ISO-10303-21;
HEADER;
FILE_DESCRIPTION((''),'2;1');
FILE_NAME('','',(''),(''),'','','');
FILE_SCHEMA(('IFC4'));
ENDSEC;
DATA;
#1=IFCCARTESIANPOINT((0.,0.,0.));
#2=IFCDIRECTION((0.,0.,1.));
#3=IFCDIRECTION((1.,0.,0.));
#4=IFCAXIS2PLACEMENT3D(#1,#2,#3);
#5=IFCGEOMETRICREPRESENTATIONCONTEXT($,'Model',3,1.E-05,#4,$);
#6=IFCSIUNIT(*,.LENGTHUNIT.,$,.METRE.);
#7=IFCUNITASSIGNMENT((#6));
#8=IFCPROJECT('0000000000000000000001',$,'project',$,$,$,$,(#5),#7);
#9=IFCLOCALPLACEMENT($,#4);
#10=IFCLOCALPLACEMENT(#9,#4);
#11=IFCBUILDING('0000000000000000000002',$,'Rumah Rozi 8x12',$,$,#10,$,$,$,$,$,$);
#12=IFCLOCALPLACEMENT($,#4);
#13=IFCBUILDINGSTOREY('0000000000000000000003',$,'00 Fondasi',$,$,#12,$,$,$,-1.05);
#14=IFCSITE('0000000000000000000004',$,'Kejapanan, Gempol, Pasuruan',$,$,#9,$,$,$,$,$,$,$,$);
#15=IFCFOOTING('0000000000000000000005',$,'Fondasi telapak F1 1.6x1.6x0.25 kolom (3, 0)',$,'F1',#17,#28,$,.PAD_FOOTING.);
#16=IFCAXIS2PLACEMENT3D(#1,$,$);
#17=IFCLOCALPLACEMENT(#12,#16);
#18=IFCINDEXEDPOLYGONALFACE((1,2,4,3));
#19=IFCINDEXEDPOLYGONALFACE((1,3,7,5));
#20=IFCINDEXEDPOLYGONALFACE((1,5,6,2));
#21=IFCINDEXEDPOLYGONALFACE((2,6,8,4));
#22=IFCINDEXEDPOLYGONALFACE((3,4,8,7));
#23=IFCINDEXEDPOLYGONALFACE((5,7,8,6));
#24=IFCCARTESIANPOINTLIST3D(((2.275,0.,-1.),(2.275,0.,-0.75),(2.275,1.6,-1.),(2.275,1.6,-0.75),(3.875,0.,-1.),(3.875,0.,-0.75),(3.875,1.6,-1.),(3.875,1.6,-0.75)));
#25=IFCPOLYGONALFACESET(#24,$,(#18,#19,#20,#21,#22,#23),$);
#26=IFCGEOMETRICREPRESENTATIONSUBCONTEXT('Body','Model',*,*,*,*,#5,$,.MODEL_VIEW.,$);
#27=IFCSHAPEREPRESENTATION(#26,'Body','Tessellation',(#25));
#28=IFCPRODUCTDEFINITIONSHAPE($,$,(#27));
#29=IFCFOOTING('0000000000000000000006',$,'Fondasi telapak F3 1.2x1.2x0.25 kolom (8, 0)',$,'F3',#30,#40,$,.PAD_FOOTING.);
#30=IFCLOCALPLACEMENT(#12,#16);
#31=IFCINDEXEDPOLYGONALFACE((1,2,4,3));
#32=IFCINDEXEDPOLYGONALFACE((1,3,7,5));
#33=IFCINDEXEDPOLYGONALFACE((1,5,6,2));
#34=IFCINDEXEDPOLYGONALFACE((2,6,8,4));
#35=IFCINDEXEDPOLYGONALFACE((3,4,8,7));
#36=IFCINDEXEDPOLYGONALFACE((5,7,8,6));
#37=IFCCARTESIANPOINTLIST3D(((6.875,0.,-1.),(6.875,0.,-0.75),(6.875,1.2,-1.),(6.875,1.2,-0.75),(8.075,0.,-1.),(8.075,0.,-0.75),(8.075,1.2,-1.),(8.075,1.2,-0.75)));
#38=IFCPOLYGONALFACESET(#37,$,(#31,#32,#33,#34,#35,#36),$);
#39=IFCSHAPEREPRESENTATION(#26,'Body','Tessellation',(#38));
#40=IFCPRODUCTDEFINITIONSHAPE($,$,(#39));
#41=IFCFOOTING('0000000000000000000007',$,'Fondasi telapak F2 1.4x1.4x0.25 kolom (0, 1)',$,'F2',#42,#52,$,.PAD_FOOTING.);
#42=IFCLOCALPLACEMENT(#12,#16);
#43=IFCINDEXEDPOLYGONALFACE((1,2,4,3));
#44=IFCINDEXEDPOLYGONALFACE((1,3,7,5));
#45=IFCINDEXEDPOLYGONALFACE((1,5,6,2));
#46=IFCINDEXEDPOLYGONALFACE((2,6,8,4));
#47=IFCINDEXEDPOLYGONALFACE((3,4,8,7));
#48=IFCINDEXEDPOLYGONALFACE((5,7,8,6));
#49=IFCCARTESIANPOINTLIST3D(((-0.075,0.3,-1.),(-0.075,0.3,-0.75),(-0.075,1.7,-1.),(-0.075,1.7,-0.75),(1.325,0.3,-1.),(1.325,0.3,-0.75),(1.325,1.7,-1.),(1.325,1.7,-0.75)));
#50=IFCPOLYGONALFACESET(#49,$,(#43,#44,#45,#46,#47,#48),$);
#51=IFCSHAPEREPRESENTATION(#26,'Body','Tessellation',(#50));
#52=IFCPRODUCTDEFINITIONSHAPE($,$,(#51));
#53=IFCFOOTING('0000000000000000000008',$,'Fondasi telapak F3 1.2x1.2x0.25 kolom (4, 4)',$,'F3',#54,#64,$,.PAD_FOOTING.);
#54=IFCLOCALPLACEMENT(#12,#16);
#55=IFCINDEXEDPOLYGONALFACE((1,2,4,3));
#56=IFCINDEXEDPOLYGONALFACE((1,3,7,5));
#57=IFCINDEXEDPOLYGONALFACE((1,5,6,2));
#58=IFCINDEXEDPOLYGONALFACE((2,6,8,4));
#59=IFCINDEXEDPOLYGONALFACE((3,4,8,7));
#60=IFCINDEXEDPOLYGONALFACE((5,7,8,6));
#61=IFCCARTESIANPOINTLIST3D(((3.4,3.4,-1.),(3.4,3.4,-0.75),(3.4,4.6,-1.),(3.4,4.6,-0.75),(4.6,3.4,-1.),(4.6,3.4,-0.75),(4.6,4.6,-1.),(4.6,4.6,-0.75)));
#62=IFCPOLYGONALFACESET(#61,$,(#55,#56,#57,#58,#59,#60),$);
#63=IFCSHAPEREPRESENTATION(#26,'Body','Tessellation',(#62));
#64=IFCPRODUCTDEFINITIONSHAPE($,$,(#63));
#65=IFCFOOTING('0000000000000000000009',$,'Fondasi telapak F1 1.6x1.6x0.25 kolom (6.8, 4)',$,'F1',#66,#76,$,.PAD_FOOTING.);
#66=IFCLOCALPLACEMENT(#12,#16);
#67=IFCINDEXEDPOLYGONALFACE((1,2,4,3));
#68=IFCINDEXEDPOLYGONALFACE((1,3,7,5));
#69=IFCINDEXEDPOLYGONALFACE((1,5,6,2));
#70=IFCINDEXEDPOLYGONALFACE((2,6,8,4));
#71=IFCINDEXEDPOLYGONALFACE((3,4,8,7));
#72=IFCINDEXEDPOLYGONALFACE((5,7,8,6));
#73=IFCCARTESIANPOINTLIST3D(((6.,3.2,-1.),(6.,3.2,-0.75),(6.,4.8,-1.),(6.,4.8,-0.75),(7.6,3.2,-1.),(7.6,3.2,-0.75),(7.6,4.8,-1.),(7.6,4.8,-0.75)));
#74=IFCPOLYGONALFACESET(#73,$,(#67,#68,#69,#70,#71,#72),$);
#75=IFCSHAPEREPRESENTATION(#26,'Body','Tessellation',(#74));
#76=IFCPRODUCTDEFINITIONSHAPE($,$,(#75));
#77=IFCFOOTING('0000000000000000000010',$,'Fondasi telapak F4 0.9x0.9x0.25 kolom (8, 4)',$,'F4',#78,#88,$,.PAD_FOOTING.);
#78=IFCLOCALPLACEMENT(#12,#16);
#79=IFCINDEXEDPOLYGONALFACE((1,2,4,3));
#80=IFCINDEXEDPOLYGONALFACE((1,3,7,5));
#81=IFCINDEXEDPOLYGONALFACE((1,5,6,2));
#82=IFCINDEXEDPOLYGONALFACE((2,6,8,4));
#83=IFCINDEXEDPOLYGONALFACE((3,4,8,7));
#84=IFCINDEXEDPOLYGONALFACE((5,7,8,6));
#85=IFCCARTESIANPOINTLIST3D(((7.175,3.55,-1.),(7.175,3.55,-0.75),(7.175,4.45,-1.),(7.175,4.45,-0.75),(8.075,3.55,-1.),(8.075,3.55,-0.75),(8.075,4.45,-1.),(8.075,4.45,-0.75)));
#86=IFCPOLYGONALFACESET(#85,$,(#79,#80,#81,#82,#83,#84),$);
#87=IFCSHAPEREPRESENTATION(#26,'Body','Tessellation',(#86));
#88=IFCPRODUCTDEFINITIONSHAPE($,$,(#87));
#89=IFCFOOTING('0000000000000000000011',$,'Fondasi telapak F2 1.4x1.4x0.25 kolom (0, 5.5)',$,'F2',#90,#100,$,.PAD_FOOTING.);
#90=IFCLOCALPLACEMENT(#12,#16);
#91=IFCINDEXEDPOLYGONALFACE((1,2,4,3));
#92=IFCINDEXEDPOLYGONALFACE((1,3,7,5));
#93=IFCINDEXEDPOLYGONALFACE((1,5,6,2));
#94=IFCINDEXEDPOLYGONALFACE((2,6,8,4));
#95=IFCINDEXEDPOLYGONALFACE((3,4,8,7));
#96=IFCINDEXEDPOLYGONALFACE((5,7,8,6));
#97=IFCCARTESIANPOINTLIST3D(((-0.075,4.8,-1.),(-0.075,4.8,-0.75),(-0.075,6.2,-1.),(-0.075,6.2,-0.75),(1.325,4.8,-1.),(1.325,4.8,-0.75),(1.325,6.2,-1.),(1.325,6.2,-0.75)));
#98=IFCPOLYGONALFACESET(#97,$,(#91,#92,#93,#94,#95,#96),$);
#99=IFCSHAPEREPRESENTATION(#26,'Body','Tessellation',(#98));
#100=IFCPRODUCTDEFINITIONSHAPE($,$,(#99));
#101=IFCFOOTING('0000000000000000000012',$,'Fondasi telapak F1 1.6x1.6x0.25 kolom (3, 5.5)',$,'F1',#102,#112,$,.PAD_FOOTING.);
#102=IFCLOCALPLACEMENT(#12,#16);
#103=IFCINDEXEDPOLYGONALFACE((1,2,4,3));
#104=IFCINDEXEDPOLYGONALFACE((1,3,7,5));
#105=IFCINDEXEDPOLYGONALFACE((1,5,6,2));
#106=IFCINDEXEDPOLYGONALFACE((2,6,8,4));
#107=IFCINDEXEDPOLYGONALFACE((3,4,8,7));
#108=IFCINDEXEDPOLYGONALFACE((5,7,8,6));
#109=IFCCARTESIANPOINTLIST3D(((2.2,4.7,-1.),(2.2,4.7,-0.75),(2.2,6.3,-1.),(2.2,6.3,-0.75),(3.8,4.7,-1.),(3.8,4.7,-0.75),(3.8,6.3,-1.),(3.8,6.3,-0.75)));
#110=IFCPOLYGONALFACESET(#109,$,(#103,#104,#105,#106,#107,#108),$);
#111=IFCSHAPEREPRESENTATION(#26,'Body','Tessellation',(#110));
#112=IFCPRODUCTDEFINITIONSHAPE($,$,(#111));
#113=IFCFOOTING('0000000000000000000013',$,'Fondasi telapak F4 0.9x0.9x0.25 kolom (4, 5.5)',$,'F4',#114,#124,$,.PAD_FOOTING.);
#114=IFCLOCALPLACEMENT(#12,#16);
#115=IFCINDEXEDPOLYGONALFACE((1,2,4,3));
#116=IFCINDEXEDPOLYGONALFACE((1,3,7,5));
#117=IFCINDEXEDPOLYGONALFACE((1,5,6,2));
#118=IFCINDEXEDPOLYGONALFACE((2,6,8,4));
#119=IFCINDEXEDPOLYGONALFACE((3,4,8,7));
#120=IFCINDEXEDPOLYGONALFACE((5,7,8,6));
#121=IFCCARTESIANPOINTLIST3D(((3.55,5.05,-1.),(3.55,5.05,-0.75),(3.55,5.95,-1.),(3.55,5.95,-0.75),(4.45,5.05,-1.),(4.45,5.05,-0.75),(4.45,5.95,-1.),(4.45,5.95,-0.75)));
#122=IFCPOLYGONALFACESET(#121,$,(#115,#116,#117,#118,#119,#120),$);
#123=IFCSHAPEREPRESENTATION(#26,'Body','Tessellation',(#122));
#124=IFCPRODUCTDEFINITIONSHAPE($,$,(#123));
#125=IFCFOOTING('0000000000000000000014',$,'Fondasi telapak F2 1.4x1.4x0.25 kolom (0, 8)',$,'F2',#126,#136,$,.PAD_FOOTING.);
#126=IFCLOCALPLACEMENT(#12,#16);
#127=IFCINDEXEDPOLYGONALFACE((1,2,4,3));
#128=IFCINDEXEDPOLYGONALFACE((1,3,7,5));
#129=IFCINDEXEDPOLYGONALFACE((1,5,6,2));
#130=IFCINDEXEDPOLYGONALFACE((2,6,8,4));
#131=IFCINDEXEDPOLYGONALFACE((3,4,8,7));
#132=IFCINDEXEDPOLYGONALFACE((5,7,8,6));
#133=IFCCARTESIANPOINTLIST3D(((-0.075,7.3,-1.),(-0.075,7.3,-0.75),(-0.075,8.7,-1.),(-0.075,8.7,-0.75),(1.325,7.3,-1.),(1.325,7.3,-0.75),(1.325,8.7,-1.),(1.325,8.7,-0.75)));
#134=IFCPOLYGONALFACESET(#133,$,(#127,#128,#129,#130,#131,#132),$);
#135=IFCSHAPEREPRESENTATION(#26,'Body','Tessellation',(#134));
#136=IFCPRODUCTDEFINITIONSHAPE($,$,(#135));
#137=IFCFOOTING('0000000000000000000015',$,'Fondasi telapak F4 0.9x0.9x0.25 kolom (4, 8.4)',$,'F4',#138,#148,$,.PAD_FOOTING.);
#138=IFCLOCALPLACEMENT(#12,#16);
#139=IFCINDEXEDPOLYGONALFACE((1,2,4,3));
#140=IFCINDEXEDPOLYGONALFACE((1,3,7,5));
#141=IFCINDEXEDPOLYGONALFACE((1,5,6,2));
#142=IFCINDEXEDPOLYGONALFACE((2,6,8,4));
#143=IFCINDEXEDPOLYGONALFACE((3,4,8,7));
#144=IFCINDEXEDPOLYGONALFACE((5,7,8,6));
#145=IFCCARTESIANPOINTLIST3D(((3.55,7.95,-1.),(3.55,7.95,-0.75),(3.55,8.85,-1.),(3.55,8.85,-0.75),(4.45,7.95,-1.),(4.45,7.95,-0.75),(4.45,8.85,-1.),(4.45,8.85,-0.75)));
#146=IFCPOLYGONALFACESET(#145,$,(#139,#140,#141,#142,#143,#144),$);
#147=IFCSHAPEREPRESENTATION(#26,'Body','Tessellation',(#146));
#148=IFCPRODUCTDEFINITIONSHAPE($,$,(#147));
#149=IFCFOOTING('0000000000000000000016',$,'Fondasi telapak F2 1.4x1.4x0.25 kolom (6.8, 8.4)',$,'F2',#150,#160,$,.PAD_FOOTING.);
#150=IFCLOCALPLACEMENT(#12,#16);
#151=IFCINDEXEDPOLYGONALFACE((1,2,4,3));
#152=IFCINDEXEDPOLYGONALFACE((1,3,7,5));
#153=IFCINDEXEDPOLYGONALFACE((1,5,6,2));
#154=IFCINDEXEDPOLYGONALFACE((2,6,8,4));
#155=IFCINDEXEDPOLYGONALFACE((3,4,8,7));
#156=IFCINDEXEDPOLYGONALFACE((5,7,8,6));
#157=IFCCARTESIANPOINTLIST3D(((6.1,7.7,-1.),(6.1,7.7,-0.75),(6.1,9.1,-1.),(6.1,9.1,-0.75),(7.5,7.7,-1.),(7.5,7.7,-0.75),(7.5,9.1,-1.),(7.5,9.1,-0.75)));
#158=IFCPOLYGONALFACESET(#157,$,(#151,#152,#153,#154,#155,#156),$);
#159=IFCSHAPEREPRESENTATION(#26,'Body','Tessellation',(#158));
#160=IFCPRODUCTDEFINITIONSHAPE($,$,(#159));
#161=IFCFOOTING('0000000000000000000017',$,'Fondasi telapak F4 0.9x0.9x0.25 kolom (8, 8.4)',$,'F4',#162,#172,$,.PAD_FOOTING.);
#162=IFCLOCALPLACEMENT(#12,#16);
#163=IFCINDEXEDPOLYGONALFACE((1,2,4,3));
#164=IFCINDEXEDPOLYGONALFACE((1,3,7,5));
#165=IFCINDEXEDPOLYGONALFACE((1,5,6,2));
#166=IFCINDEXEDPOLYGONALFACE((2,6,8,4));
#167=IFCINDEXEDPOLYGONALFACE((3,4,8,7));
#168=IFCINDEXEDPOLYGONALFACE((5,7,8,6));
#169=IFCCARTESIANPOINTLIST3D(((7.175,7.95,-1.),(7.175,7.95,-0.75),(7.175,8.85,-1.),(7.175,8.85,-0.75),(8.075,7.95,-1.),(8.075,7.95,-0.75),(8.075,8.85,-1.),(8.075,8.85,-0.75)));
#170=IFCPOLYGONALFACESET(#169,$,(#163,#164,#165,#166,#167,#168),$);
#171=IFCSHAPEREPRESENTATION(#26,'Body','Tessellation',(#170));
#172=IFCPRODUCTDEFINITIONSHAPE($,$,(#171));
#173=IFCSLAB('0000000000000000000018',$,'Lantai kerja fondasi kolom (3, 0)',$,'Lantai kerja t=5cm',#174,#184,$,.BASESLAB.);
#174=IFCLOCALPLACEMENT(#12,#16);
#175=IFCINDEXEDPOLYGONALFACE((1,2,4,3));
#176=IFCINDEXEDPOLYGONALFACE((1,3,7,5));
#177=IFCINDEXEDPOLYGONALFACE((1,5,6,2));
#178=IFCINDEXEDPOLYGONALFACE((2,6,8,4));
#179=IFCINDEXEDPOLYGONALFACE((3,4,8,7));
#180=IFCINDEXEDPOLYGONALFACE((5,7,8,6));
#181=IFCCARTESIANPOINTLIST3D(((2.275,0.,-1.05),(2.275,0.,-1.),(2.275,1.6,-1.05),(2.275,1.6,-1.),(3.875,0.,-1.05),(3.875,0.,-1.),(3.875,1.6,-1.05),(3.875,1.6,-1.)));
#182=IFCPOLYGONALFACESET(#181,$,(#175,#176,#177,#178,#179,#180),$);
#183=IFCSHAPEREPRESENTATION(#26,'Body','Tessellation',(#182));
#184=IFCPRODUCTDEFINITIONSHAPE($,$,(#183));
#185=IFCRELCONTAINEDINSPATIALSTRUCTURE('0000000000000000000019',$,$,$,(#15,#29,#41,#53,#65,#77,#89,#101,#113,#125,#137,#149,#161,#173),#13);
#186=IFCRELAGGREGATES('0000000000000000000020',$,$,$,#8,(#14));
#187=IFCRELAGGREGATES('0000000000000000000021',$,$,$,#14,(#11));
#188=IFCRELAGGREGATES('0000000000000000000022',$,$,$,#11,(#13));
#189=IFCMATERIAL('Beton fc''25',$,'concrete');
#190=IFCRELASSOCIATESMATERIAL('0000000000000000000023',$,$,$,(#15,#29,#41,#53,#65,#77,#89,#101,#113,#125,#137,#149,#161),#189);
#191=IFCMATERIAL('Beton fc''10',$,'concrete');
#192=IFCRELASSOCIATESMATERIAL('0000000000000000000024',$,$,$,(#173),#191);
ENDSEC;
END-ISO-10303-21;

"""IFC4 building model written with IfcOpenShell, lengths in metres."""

from ifc_helpers import new_model, si_unit, frame, origin_with_axes, place, context, subcontext, project, spatial, line, indexed_curve, outline, extrude, material, element, save


model = new_model("IFC4")

# Units and contexts
model_context = context("Model", 3, precision=1e-05, world=origin_with_axes())
body_context = subcontext(model_context, "Body", "Model", "MODEL_VIEW")
ifc_project = project(units=[si_unit("LENGTHUNIT", "METRE")], contexts=[model_context])

# Site, building, storey
site_placement = place(None, origin_with_axes())
site = spatial("IfcSite", under=ifc_project, at=site_placement, Name="Kejapanan, Gempol, Pasuruan")
building_placement = place(site_placement, origin_with_axes())
building = spatial("IfcBuilding", under=site, at=building_placement, Name="Rumah Rozi 8x12")
storey_placement = place(None, origin_with_axes())
storey = spatial("IfcBuildingStorey", under=building, at=storey_placement, Name="00 Fondasi", Elevation=-1.05)

# Footings
ifc_material_1 = material(Name="Beton fc'25", Category="concrete")
footing_1_placement = place(storey_placement, origin_with_axes())
element("IfcFooting", 1, at=footing_1_placement, inside=storey, material=ifc_material_1, Name="Fondasi telapak F1 1.6x1.6x0.25 kolom (3, 0)", ObjectType="F1", PredefinedType="PAD_FOOTING", context=body_context, shape_type="SweptSolid", body=[
    extrude(outline(indexed_curve([(2.275, 0.0), (3.875, 0.0), (3.875, 1.6), (2.275, 1.6)], segments=[line(1, 2, 3, 4, 1)])), frame((0.0, 0.0, -1.0), z_axis=(0.0, 0.0, 1.0), x_axis=(1.0, 0.0, 0.0)), (0.0, 0.0, 1.0), 0.25),
])
footing_2_placement = place(storey_placement, origin_with_axes())
element("IfcFooting", 2, at=footing_2_placement, inside=storey, material=ifc_material_1, Name="Fondasi telapak F3 1.2x1.2x0.25 kolom (8, 0)", ObjectType="F3", PredefinedType="PAD_FOOTING", context=body_context, shape_type="SweptSolid", body=[
    extrude(outline(indexed_curve([(6.875, 0.0), (8.075, 0.0), (8.075, 1.2), (6.875, 1.2)], segments=[line(1, 2, 3, 4, 1)])), frame((0.0, 0.0, -1.0), z_axis=(0.0, 0.0, 1.0), x_axis=(1.0, 0.0, 0.0)), (0.0, 0.0, 1.0), 0.25),
])
footing_3_placement = place(storey_placement, origin_with_axes())
element("IfcFooting", 3, at=footing_3_placement, inside=storey, material=ifc_material_1, Name="Fondasi telapak F2 1.4x1.4x0.25 kolom (0, 1)", ObjectType="F2", PredefinedType="PAD_FOOTING", context=body_context, shape_type="SweptSolid", body=[
    extrude(outline(indexed_curve([(-0.075, 0.3), (1.325, 0.3), (1.325, 1.7), (-0.075, 1.7)], segments=[line(1, 2, 3, 4, 1)])), frame((0.0, 0.0, -1.0), z_axis=(0.0, 0.0, 1.0), x_axis=(1.0, 0.0, 0.0)), (0.0, 0.0, 1.0), 0.25),
])
footing_4_placement = place(storey_placement, origin_with_axes())
element("IfcFooting", 4, at=footing_4_placement, inside=storey, material=ifc_material_1, Name="Fondasi telapak F3 1.2x1.2x0.25 kolom (4, 4)", ObjectType="F3", PredefinedType="PAD_FOOTING", context=body_context, shape_type="SweptSolid", body=[
    extrude(outline(indexed_curve([(3.4, 3.4), (4.6, 3.4), (4.6, 4.6), (3.4, 4.6)], segments=[line(1, 2, 3, 4, 1)])), frame((0.0, 0.0, -1.0), z_axis=(0.0, 0.0, 1.0), x_axis=(1.0, 0.0, 0.0)), (0.0, 0.0, 1.0), 0.25),
])
footing_5_placement = place(storey_placement, origin_with_axes())
element("IfcFooting", 5, at=footing_5_placement, inside=storey, material=ifc_material_1, Name="Fondasi telapak F1 1.6x1.6x0.25 kolom (6.8, 4)", ObjectType="F1", PredefinedType="PAD_FOOTING", context=body_context, shape_type="SweptSolid", body=[
    extrude(outline(indexed_curve([(6.0, 3.2), (7.6, 3.2), (7.6, 4.8), (6.0, 4.8)], segments=[line(1, 2, 3, 4, 1)])), frame((0.0, 0.0, -1.0), z_axis=(0.0, 0.0, 1.0), x_axis=(1.0, 0.0, 0.0)), (0.0, 0.0, 1.0), 0.25),
])
footing_6_placement = place(storey_placement, origin_with_axes())
element("IfcFooting", 6, at=footing_6_placement, inside=storey, material=ifc_material_1, Name="Fondasi telapak F4 0.9x0.9x0.25 kolom (8, 4)", ObjectType="F4", PredefinedType="PAD_FOOTING", context=body_context, shape_type="SweptSolid", body=[
    extrude(outline(indexed_curve([(7.175, 3.55), (8.075, 3.55), (8.075, 4.45), (7.175, 4.45)], segments=[line(1, 2, 3, 4, 1)])), frame((0.0, 0.0, -1.0), z_axis=(0.0, 0.0, 1.0), x_axis=(1.0, 0.0, 0.0)), (0.0, 0.0, 1.0), 0.25),
])
footing_7_placement = place(storey_placement, origin_with_axes())
element("IfcFooting", 7, at=footing_7_placement, inside=storey, material=ifc_material_1, Name="Fondasi telapak F2 1.4x1.4x0.25 kolom (0, 5.5)", ObjectType="F2", PredefinedType="PAD_FOOTING", context=body_context, shape_type="SweptSolid", body=[
    extrude(outline(indexed_curve([(-0.075, 4.8), (1.325, 4.8), (1.325, 6.2), (-0.075, 6.2)], segments=[line(1, 2, 3, 4, 1)])), frame((0.0, 0.0, -1.0), z_axis=(0.0, 0.0, 1.0), x_axis=(1.0, 0.0, 0.0)), (0.0, 0.0, 1.0), 0.25),
])
footing_8_placement = place(storey_placement, origin_with_axes())
element("IfcFooting", 8, at=footing_8_placement, inside=storey, material=ifc_material_1, Name="Fondasi telapak F1 1.6x1.6x0.25 kolom (3, 5.5)", ObjectType="F1", PredefinedType="PAD_FOOTING", context=body_context, shape_type="SweptSolid", body=[
    extrude(outline(indexed_curve([(2.2, 4.7), (3.8, 4.7), (3.8, 6.3), (2.2, 6.3)], segments=[line(1, 2, 3, 4, 1)])), frame((0.0, 0.0, -1.0), z_axis=(0.0, 0.0, 1.0), x_axis=(1.0, 0.0, 0.0)), (0.0, 0.0, 1.0), 0.25),
])
footing_9_placement = place(storey_placement, origin_with_axes())
element("IfcFooting", 9, at=footing_9_placement, inside=storey, material=ifc_material_1, Name="Fondasi telapak F4 0.9x0.9x0.25 kolom (4, 5.5)", ObjectType="F4", PredefinedType="PAD_FOOTING", context=body_context, shape_type="SweptSolid", body=[
    extrude(outline(indexed_curve([(3.55, 5.05), (4.45, 5.05), (4.45, 5.95), (3.55, 5.95)], segments=[line(1, 2, 3, 4, 1)])), frame((0.0, 0.0, -1.0), z_axis=(0.0, 0.0, 1.0), x_axis=(1.0, 0.0, 0.0)), (0.0, 0.0, 1.0), 0.25),
])
footing_10_placement = place(storey_placement, origin_with_axes())
element("IfcFooting", 10, at=footing_10_placement, inside=storey, material=ifc_material_1, Name="Fondasi telapak F2 1.4x1.4x0.25 kolom (0, 8)", ObjectType="F2", PredefinedType="PAD_FOOTING", context=body_context, shape_type="SweptSolid", body=[
    extrude(outline(indexed_curve([(-0.075, 7.3), (1.325, 7.3), (1.325, 8.7), (-0.075, 8.7)], segments=[line(1, 2, 3, 4, 1)])), frame((0.0, 0.0, -1.0), z_axis=(0.0, 0.0, 1.0), x_axis=(1.0, 0.0, 0.0)), (0.0, 0.0, 1.0), 0.25),
])
footing_11_placement = place(storey_placement, origin_with_axes())
element("IfcFooting", 11, at=footing_11_placement, inside=storey, material=ifc_material_1, Name="Fondasi telapak F4 0.9x0.9x0.25 kolom (4, 8.4)", ObjectType="F4", PredefinedType="PAD_FOOTING", context=body_context, shape_type="SweptSolid", body=[
    extrude(outline(indexed_curve([(3.55, 7.95), (4.45, 7.95), (4.45, 8.85), (3.55, 8.85)], segments=[line(1, 2, 3, 4, 1)])), frame((0.0, 0.0, -1.0), z_axis=(0.0, 0.0, 1.0), x_axis=(1.0, 0.0, 0.0)), (0.0, 0.0, 1.0), 0.25),
])
footing_12_placement = place(storey_placement, origin_with_axes())
element("IfcFooting", 12, at=footing_12_placement, inside=storey, material=ifc_material_1, Name="Fondasi telapak F2 1.4x1.4x0.25 kolom (6.8, 8.4)", ObjectType="F2", PredefinedType="PAD_FOOTING", context=body_context, shape_type="SweptSolid", body=[
    extrude(outline(indexed_curve([(6.1, 7.7), (7.5, 7.7), (7.5, 9.1), (6.1, 9.1)], segments=[line(1, 2, 3, 4, 1)])), frame((0.0, 0.0, -1.0), z_axis=(0.0, 0.0, 1.0), x_axis=(1.0, 0.0, 0.0)), (0.0, 0.0, 1.0), 0.25),
])
footing_13_placement = place(storey_placement, origin_with_axes())
element("IfcFooting", 13, at=footing_13_placement, inside=storey, material=ifc_material_1, Name="Fondasi telapak F4 0.9x0.9x0.25 kolom (8, 8.4)", ObjectType="F4", PredefinedType="PAD_FOOTING", context=body_context, shape_type="SweptSolid", body=[
    extrude(outline(indexed_curve([(7.175, 7.95), (8.075, 7.95), (8.075, 8.85), (7.175, 8.85)], segments=[line(1, 2, 3, 4, 1)])), frame((0.0, 0.0, -1.0), z_axis=(0.0, 0.0, 1.0), x_axis=(1.0, 0.0, 0.0)), (0.0, 0.0, 1.0), 0.25),
])

# Slab
ifc_material_2 = material(Name="Beton fc'10", Category="concrete")
slab_1_placement = place(storey_placement, origin_with_axes())
element("IfcSlab", 14, at=slab_1_placement, inside=storey, material=ifc_material_2, Name="Lantai kerja fondasi kolom (3, 0)", ObjectType="Lantai kerja t=5cm", PredefinedType="BASESLAB", context=body_context, shape_type="SweptSolid", body=[
    extrude(outline(indexed_curve([(2.275, 0.0), (3.875, 0.0), (3.875, 1.6), (2.275, 1.6)], segments=[line(1, 2, 3, 4, 1)])), frame((0.0, 0.0, -1.05), z_axis=(0.0, 0.0, 1.0), x_axis=(1.0, 0.0, 0.0)), (0.0, 0.0, 1.0), 0.05),
])

save(model, "model.ifc")
